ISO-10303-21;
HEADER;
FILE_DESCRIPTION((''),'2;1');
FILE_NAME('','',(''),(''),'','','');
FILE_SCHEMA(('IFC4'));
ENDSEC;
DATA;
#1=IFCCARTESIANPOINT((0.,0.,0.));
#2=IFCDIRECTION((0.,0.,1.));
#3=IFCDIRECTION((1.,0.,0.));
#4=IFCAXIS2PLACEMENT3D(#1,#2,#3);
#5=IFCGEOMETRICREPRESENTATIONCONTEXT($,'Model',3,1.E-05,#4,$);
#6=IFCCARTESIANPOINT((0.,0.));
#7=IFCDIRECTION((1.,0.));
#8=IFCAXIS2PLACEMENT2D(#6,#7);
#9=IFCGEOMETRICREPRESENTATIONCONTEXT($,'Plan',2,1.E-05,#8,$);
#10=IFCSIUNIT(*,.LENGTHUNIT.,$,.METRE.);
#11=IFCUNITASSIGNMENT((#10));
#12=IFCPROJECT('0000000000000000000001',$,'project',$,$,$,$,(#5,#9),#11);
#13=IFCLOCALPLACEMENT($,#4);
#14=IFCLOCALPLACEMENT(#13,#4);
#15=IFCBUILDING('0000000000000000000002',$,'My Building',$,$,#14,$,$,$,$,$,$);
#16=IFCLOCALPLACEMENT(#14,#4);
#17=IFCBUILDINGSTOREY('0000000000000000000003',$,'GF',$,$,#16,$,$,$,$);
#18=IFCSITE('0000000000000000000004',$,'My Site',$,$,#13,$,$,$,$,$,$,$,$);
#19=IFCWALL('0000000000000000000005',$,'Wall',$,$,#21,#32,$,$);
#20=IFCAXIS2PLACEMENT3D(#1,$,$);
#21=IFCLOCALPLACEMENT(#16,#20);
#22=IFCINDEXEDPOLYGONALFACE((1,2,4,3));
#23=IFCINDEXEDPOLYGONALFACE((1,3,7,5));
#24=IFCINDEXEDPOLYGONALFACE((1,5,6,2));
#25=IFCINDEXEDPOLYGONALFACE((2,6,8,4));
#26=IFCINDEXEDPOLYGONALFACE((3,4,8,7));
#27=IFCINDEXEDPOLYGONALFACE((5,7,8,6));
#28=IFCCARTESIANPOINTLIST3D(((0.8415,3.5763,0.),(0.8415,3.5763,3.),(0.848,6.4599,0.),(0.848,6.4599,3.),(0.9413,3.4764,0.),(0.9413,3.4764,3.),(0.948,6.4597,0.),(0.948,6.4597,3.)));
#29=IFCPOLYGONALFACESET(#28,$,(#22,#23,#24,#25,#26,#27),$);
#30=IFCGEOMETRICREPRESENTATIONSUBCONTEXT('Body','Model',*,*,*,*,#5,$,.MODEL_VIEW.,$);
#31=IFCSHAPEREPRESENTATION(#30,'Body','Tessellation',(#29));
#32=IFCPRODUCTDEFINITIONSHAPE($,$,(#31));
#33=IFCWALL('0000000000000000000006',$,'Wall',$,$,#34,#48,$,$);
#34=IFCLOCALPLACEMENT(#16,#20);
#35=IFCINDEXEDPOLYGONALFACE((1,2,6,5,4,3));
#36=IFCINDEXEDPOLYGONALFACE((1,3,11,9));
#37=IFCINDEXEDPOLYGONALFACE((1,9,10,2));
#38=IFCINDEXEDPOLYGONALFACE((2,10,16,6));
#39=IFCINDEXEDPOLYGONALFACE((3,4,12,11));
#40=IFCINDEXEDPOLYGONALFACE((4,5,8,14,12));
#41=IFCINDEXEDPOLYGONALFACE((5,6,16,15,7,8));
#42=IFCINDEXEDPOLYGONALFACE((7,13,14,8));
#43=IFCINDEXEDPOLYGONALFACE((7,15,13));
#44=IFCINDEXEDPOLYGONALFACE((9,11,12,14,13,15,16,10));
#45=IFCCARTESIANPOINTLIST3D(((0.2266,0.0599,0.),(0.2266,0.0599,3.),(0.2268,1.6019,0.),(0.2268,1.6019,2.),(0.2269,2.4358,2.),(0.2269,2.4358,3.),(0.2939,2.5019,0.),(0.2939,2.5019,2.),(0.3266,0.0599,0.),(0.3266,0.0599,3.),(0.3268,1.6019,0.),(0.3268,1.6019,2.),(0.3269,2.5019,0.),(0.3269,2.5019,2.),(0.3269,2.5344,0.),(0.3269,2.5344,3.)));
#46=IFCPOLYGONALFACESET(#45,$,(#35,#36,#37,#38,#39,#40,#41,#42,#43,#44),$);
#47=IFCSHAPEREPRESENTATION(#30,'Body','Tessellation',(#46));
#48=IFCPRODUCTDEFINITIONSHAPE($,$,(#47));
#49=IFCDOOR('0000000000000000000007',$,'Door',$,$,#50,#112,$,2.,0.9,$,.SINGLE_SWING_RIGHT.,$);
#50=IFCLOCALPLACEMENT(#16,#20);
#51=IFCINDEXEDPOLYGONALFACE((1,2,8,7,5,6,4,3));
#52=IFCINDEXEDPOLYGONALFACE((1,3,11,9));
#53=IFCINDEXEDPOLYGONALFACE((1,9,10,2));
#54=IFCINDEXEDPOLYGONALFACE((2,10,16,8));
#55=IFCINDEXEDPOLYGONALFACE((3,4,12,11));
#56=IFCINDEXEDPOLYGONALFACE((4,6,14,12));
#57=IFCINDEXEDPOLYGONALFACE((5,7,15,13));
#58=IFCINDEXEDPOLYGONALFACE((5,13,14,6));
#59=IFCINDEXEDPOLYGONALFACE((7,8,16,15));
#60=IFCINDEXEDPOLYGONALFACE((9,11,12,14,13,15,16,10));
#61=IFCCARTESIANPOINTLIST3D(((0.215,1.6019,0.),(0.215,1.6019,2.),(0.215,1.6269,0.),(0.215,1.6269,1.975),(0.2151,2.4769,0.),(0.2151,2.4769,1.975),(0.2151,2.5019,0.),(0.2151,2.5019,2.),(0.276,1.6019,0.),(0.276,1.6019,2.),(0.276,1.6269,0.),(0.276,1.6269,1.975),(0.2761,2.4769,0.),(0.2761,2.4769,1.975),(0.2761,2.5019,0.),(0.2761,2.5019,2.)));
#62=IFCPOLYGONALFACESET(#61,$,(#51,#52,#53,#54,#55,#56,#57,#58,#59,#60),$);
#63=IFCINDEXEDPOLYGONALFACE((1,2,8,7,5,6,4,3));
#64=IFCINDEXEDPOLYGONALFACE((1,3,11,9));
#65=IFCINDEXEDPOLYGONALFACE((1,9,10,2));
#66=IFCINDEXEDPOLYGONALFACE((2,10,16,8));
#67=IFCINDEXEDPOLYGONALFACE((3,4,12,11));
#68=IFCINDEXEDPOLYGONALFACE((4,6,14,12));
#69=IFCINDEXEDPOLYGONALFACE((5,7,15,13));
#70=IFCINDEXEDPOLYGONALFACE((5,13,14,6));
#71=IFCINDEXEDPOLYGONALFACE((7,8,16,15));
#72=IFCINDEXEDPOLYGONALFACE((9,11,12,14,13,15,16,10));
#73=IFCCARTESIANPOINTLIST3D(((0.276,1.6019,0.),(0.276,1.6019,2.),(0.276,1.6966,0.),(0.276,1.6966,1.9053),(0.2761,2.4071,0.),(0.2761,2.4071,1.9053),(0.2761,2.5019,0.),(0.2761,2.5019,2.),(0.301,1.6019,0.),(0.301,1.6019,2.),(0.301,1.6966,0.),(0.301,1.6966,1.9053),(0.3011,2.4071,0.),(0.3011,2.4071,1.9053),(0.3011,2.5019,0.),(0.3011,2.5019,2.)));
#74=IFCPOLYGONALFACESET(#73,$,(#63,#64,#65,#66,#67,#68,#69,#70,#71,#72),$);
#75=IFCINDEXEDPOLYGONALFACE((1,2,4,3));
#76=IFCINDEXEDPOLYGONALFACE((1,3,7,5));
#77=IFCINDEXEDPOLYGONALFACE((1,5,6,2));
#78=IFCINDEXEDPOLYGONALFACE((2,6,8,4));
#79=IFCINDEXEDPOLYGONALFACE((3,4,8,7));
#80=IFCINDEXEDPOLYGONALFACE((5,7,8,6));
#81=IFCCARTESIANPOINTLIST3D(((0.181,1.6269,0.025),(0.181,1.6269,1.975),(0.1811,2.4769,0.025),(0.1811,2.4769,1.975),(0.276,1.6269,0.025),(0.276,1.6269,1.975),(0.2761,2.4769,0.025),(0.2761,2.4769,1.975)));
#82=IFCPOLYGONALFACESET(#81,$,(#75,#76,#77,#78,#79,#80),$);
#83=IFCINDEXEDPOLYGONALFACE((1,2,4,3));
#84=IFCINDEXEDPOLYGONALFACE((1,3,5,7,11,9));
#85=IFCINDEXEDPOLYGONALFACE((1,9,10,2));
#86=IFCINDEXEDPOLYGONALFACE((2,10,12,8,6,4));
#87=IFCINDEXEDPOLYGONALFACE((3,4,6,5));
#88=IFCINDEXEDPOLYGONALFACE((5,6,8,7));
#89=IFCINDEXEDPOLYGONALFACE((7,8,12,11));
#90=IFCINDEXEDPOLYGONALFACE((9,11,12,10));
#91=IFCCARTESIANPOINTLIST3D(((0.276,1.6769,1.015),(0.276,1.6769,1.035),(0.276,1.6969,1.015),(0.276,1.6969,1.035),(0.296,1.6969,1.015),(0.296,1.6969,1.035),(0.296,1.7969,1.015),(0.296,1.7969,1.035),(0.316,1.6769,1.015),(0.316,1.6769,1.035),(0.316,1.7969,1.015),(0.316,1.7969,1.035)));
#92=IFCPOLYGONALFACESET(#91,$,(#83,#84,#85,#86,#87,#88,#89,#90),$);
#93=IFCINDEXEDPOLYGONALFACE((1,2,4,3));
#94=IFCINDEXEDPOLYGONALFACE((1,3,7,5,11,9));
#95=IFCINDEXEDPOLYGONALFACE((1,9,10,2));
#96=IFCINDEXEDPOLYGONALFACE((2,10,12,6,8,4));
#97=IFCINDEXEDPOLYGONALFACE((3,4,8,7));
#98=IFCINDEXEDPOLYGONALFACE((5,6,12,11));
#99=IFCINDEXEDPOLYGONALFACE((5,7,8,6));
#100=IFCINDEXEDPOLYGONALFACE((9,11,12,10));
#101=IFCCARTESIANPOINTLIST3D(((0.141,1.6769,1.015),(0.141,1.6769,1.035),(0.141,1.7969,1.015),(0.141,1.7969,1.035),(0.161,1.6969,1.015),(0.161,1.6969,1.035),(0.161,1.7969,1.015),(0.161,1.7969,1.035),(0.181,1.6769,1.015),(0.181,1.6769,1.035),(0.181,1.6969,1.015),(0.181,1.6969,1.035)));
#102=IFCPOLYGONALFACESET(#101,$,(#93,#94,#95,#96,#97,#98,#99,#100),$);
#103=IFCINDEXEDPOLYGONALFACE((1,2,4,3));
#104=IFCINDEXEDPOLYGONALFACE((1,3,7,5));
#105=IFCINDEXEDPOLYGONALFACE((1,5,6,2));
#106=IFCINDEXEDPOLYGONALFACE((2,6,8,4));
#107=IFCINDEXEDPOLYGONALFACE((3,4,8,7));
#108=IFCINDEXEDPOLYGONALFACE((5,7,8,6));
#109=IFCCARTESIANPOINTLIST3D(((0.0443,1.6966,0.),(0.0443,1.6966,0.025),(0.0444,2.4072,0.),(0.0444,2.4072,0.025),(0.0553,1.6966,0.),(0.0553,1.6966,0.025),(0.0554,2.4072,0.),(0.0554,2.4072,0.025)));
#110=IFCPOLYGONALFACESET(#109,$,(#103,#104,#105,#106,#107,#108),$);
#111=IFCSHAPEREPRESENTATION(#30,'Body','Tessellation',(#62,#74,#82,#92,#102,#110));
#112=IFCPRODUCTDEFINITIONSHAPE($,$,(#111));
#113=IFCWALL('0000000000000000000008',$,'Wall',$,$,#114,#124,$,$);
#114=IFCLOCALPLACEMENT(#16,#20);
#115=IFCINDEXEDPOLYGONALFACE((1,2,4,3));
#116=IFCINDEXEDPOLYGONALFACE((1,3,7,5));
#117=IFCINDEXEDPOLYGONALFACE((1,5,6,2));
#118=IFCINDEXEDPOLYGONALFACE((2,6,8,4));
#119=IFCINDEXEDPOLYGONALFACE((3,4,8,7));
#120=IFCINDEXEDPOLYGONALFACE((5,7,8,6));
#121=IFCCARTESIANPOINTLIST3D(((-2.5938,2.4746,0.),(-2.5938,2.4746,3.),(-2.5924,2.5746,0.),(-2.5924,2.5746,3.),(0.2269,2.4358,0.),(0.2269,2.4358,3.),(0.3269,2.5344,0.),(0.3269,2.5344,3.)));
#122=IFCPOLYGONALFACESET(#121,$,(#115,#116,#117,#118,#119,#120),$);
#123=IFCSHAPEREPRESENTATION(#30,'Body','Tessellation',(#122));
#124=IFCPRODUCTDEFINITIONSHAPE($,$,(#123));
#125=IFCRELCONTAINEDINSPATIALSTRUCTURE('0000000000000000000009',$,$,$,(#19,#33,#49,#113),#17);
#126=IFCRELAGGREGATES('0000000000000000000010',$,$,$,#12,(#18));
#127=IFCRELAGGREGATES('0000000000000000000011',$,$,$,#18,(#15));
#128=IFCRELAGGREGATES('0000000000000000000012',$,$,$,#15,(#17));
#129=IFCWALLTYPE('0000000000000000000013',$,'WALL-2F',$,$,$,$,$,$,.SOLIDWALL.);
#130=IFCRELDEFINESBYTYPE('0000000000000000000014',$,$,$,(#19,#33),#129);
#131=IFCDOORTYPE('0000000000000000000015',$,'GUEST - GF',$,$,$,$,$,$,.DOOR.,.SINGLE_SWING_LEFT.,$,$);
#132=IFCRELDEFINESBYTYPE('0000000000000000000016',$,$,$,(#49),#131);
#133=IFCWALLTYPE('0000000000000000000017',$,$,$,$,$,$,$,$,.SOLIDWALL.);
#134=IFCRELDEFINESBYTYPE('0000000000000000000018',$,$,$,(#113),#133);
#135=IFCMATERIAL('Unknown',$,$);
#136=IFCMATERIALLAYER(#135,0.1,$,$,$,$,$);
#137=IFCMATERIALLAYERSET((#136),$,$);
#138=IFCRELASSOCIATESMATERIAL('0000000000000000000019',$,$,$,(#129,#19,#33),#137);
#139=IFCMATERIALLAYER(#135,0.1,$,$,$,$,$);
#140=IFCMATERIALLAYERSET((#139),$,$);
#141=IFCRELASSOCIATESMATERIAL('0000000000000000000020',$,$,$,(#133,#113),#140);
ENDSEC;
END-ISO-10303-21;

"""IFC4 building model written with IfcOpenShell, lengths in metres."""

from ifc_helpers import new_model, entity, si_unit, frame, origin_with_axes, origin_2d_with_axis, place, context, subcontext, project, spatial, line, indexed_curve, outline, extrude, shape, source, transform, mapped, material, layer, layer_set, layer_usage, type_object, type_shapes, element, fill, save


model = new_model("IFC4")

# Units and contexts
model_context = context("Model", 3, precision=1e-05, world=origin_with_axes())
plan_context = context("Plan", 2, precision=1e-05, world=origin_2d_with_axis())
body_context_1 = subcontext(model_context, "Body", "Model", "MODEL_VIEW")
body_context_2 = subcontext(plan_context, "Body", "Plan", "PLAN_VIEW")
ifc_project = project(units=[si_unit("LENGTHUNIT", "METRE")], contexts=[model_context, plan_context])

# Site, building, storey
site_placement = place(None, origin_with_axes())
site = spatial("IfcSite", under=ifc_project, at=site_placement, Name="My Site")
building_placement = place(site_placement, origin_with_axes())
building = spatial("IfcBuilding", under=site, at=building_placement, Name="My Building")
storey_placement = place(building_placement, origin_with_axes())
storey = spatial("IfcBuildingStorey", under=building, at=storey_placement, Name="GF")

# Shared definitions
ifc_material = material(Name="Unknown")

# Shared definitions
ifc_layer_1 = layer(ifc_material, 0.1)
ifc_layer_set_1 = layer_set([ifc_layer_1])
wall_type_1 = type_object("IfcWallType", Name="WALL-2F", PredefinedType="SOLIDWALL", material=ifc_layer_set_1)

# Wall
ifc_layer_usage_1 = layer_usage(ifc_layer_set_1, "AXIS2", "POSITIVE", 0.0)
wall_1_placement = place(storey_placement, frame((0.848, 6.4599, 0.0), z_axis=(0.0, 0.0, 1.0), x_axis=(-0.00226, -0.999997, 0.0)))
element("IfcWall", 1, at=wall_1_placement, inside=storey, type_object=wall_type_1, material=ifc_layer_usage_1, Name="Wall", context=body_context_1, shape_type="SweptSolid", body=[
    extrude(outline(indexed_curve([(0.0, 0.0), (0.0, 0.1), (2.9833, 0.1), (2.8836, 0.0)], segments=[line(1, 2, 3, 4, 1)])), origin_with_axes(), (0.0, 0.0, 1.0), 3.0),
])

# Wall, opening, door
ifc_layer_usage_2 = layer_usage(ifc_layer_set_1, "AXIS2", "POSITIVE", 0.0)
wall_2_placement = place(storey_placement, frame((0.2269, 2.5358, 0.0), z_axis=(0.0, 0.0, 1.0), x_axis=(-0.000105, -1.0, 0.0)))
wall_2 = element("IfcWall", 2, at=wall_2_placement, inside=storey, type_object=wall_type_1, material=ifc_layer_usage_2, Name="Wall", context=body_context_1, shape_type="SweptSolid", body=[
    extrude(outline(indexed_curve([(0.1, 0.0), (0.0014, 0.1), (2.4759, 0.1), (2.4759, 0.0)], segments=[line(1, 2, 3, 4, 1)])), origin_with_axes(), (0.0, 0.0, 1.0), 3.0),
])
shared_shape_1 = source(origin_with_axes(), body_context_1, "Body", "SweptSolid", [
    extrude(outline(indexed_curve([(0.0, 0.0), (0.9, 0.0), (0.9, 2.0), (0.0, 2.0)], segments=[line(1, 2, 3, 4, 1)])), frame((0.0, -0.6, 0.0), z_axis=(0.0, -1.0, 0.0), x_axis=(1.0, 0.0, 0.0)), (0.0, 0.0, -1.0), 1.2),
])
opening_1_placement = place(wall_2_placement, frame((0.9339, 0.2103, 0.0), z_axis=(0.0, 0.0, 1.0), x_axis=(-1.0, 0.0, 0.0)))
opening_1 = element("IfcOpeningElement", 3, at=opening_1_placement, cuts=wall_2, PredefinedType="OPENING", context=body_context_1, shape_type="MappedRepresentation", body=[
    mapped(shared_shape_1, transform((0.0, 0.0, 0.0), x_axis=(1.0, 0.0, 0.0), y_axis=(0.0, 1.0, 0.0), z_axis=(0.0, 0.0, 1.0), scale=1.0)),
])
door_type_1 = type_object("IfcDoorType", Name="GUEST - GF", OperationType="SINGLE_SWING_LEFT", PredefinedType="DOOR")
shared_shape_2 = source(origin_with_axes(), body_context_1, "Body", "SweptSolid", [
    extrude(outline(indexed_curve([(0.0, 0.0), (0.0, 2.0), (0.9, 2.0), (0.9, 0.0), (0.875, 0.0), (0.875, 1.975), (0.025, 1.975), (0.025, 0.0)], segments=[line(1, 2, 3, 4, 5, 6, 7, 8, 1)])), frame((0.0, 0.0093, 0.0), z_axis=(0.0, -1.0, 0.0), x_axis=(1.0, 0.0, 0.0)), (0.0, 0.0, -1.0), 0.061),
    extrude(outline(indexed_curve([(0.0, 0.0), (0.0, 2.0), (0.9, 2.0), (0.9, 0.0), (0.8053, 0.0), (0.8053, 1.9053), (0.0947, 1.9053), (0.0947, 0.0)], segments=[line(1, 2, 3, 4, 5, 6, 7, 8, 1)])), frame((0.0, -0.0157, 0.0), z_axis=(0.0, -1.0, 0.0), x_axis=(1.0, 0.0, 0.0)), (0.0, 0.0, -1.0), 0.025),
    extrude(outline(indexed_curve([(0.0, 0.0), (0.85, 0.0), (0.85, 0.095), (0.0, 0.095)], segments=[line(1, 2, 3, 4, 1)])), frame((0.025, 0.0093, 0.025), z_axis=(0.0, 0.0, 1.0), x_axis=(1.0, 0.0, 0.0)), (0.0, 0.0, 1.0), 1.95),
    extrude(outline(indexed_curve([(0.0, 0.0), (0.0, -0.04), (0.12, -0.04), (0.12, -0.02), (0.02, -0.02), (0.02, 0.0)], segments=[line(1, 2, 3, 4, 5, 6, 1)])), frame((0.075, 0.0093, 1.015), z_axis=(0.0, 0.0, 1.0), x_axis=(1.0, 0.0, 0.0)), (0.0, 0.0, 1.0), 0.02),
    extrude(outline(indexed_curve([(0.0, 0.0), (0.0, 0.04), (0.12, 0.04), (0.12, 0.02), (0.02, 0.02), (0.02, 0.0)], segments=[line(1, 2, 3, 4, 5, 6, 1)])), frame((0.075, 0.1043, 1.015), z_axis=(0.0, 0.0, 1.0), x_axis=(1.0, 0.0, 0.0)), (0.0, 0.0, 1.0), 0.02),
    extrude(outline(indexed_curve([(0.0, 0.0), (0.7105, 0.0), (0.7105, 0.011), (0.0, 0.011)], segments=[line(1, 2, 3, 4, 1)])), frame((0.0947, 0.23, 0.0), z_axis=(0.0, 0.0, 1.0), x_axis=(1.0, 0.0, 0.0)), (0.0, 0.0, 1.0), 0.025),
])
shared_shape_3 = source(origin_with_axes(), body_context_2, "Body", "Curve2D", [
    entity("IfcIndexedPolyCurve", entity("IfcCartesianPointList2D", [[0.0, -0.0157], [0.0, 0.0703], [0.025, 0.0703], [0.025, 0.0093], [0.0947, 0.0093], [0.0947, -0.0157]]), [entity("IfcLineIndex", [1, 2, 3, 4, 5, 6, 1])]),
    entity("IfcIndexedPolyCurve", entity("IfcCartesianPointList2D", [[0.9, -0.0157], [0.9, 0.0703], [0.875, 0.0703], [0.875, 0.0093], [0.8053, 0.0093], [0.8053, -0.0157]]), [entity("IfcLineIndex", [1, 2, 3, 4, 5, 6, 1])]),
    entity("IfcTrimmedCurve", entity("IfcEllipse", entity("IfcAxis2Placement2D", entity("IfcCartesianPoint", [0.78, 0.0703]), entity("IfcDirection", [1.0, 0.0])), 0.755, 0.85), [entity("IfcCartesianPoint", [0.78, 0.9203])], [entity("IfcCartesianPoint", [0.025, 0.0703])], True, "CARTESIAN"),
    entity("IfcIndexedPolyCurve", entity("IfcCartesianPointList2D", [[0.875, 0.0703], [0.78, 0.0703], [0.78, 0.9203], [0.875, 0.9203]]), [entity("IfcLineIndex", [1, 2, 3, 4, 1])]),
])
type_shapes(door_type_1, [shared_shape_2, shared_shape_3])
door_1_placement = place(opening_1_placement, frame((0.0, 0.1518, 0.0), z_axis=(0.0, 0.0, 1.0), x_axis=(1.0, 0.0, 0.0)))
door_1 = element("IfcDoor", 4, at=door_1_placement, inside=storey, type_object=door_type_1, Name="Door", OperationType="SINGLE_SWING_RIGHT", OverallHeight=2.0, OverallWidth=0.9, shapes=[
    shape(body_context_1, "Body", "MappedRepresentation", [mapped(shared_shape_2, transform((0.0, 0.0, 0.0), x_axis=(1.0, 0.0, 0.0), y_axis=(0.0, 1.0, 0.0), z_axis=(0.0, 0.0, 1.0), scale=1.0))]),
    shape(body_context_2, "Body", "MappedRepresentation", [mapped(shared_shape_3, transform((0.0, 0.0, 0.0), x_axis=(1.0, 0.0, 0.0), y_axis=(0.0, 1.0, 0.0), z_axis=(0.0, 0.0, 1.0), scale=1.0))]),
])
fill(opening_1, door_1)

# Wall
ifc_layer_2 = layer(ifc_material, 0.1)
ifc_layer_set_2 = layer_set([ifc_layer_2])
ifc_layer_usage_3 = layer_usage(ifc_layer_set_2, "AXIS2", "POSITIVE", 0.0)
wall_type_2 = type_object("IfcWallType", PredefinedType="SOLIDWALL", material=ifc_layer_set_2)
wall_3_placement = place(storey_placement, frame((0.2269, 2.5358, 0.0), z_axis=(0.0, 0.0, 1.0), x_axis=(-0.999905, 0.013761, 0.0)))
element("IfcWall", 5, at=wall_3_placement, inside=storey, type_object=wall_type_2, material=ifc_layer_usage_3, Name="Wall", context=body_context_1, shape_type="SweptSolid", body=[
    extrude(outline(indexed_curve([(-0.1, 0.0), (-0.0014, 0.1), (2.8195, 0.1), (2.8195, 0.0)], segments=[line(1, 2, 3, 4, 1)])), origin_with_axes(), (0.0, 0.0, 1.0), 3.0),
])

save(model, "model.ifc")
